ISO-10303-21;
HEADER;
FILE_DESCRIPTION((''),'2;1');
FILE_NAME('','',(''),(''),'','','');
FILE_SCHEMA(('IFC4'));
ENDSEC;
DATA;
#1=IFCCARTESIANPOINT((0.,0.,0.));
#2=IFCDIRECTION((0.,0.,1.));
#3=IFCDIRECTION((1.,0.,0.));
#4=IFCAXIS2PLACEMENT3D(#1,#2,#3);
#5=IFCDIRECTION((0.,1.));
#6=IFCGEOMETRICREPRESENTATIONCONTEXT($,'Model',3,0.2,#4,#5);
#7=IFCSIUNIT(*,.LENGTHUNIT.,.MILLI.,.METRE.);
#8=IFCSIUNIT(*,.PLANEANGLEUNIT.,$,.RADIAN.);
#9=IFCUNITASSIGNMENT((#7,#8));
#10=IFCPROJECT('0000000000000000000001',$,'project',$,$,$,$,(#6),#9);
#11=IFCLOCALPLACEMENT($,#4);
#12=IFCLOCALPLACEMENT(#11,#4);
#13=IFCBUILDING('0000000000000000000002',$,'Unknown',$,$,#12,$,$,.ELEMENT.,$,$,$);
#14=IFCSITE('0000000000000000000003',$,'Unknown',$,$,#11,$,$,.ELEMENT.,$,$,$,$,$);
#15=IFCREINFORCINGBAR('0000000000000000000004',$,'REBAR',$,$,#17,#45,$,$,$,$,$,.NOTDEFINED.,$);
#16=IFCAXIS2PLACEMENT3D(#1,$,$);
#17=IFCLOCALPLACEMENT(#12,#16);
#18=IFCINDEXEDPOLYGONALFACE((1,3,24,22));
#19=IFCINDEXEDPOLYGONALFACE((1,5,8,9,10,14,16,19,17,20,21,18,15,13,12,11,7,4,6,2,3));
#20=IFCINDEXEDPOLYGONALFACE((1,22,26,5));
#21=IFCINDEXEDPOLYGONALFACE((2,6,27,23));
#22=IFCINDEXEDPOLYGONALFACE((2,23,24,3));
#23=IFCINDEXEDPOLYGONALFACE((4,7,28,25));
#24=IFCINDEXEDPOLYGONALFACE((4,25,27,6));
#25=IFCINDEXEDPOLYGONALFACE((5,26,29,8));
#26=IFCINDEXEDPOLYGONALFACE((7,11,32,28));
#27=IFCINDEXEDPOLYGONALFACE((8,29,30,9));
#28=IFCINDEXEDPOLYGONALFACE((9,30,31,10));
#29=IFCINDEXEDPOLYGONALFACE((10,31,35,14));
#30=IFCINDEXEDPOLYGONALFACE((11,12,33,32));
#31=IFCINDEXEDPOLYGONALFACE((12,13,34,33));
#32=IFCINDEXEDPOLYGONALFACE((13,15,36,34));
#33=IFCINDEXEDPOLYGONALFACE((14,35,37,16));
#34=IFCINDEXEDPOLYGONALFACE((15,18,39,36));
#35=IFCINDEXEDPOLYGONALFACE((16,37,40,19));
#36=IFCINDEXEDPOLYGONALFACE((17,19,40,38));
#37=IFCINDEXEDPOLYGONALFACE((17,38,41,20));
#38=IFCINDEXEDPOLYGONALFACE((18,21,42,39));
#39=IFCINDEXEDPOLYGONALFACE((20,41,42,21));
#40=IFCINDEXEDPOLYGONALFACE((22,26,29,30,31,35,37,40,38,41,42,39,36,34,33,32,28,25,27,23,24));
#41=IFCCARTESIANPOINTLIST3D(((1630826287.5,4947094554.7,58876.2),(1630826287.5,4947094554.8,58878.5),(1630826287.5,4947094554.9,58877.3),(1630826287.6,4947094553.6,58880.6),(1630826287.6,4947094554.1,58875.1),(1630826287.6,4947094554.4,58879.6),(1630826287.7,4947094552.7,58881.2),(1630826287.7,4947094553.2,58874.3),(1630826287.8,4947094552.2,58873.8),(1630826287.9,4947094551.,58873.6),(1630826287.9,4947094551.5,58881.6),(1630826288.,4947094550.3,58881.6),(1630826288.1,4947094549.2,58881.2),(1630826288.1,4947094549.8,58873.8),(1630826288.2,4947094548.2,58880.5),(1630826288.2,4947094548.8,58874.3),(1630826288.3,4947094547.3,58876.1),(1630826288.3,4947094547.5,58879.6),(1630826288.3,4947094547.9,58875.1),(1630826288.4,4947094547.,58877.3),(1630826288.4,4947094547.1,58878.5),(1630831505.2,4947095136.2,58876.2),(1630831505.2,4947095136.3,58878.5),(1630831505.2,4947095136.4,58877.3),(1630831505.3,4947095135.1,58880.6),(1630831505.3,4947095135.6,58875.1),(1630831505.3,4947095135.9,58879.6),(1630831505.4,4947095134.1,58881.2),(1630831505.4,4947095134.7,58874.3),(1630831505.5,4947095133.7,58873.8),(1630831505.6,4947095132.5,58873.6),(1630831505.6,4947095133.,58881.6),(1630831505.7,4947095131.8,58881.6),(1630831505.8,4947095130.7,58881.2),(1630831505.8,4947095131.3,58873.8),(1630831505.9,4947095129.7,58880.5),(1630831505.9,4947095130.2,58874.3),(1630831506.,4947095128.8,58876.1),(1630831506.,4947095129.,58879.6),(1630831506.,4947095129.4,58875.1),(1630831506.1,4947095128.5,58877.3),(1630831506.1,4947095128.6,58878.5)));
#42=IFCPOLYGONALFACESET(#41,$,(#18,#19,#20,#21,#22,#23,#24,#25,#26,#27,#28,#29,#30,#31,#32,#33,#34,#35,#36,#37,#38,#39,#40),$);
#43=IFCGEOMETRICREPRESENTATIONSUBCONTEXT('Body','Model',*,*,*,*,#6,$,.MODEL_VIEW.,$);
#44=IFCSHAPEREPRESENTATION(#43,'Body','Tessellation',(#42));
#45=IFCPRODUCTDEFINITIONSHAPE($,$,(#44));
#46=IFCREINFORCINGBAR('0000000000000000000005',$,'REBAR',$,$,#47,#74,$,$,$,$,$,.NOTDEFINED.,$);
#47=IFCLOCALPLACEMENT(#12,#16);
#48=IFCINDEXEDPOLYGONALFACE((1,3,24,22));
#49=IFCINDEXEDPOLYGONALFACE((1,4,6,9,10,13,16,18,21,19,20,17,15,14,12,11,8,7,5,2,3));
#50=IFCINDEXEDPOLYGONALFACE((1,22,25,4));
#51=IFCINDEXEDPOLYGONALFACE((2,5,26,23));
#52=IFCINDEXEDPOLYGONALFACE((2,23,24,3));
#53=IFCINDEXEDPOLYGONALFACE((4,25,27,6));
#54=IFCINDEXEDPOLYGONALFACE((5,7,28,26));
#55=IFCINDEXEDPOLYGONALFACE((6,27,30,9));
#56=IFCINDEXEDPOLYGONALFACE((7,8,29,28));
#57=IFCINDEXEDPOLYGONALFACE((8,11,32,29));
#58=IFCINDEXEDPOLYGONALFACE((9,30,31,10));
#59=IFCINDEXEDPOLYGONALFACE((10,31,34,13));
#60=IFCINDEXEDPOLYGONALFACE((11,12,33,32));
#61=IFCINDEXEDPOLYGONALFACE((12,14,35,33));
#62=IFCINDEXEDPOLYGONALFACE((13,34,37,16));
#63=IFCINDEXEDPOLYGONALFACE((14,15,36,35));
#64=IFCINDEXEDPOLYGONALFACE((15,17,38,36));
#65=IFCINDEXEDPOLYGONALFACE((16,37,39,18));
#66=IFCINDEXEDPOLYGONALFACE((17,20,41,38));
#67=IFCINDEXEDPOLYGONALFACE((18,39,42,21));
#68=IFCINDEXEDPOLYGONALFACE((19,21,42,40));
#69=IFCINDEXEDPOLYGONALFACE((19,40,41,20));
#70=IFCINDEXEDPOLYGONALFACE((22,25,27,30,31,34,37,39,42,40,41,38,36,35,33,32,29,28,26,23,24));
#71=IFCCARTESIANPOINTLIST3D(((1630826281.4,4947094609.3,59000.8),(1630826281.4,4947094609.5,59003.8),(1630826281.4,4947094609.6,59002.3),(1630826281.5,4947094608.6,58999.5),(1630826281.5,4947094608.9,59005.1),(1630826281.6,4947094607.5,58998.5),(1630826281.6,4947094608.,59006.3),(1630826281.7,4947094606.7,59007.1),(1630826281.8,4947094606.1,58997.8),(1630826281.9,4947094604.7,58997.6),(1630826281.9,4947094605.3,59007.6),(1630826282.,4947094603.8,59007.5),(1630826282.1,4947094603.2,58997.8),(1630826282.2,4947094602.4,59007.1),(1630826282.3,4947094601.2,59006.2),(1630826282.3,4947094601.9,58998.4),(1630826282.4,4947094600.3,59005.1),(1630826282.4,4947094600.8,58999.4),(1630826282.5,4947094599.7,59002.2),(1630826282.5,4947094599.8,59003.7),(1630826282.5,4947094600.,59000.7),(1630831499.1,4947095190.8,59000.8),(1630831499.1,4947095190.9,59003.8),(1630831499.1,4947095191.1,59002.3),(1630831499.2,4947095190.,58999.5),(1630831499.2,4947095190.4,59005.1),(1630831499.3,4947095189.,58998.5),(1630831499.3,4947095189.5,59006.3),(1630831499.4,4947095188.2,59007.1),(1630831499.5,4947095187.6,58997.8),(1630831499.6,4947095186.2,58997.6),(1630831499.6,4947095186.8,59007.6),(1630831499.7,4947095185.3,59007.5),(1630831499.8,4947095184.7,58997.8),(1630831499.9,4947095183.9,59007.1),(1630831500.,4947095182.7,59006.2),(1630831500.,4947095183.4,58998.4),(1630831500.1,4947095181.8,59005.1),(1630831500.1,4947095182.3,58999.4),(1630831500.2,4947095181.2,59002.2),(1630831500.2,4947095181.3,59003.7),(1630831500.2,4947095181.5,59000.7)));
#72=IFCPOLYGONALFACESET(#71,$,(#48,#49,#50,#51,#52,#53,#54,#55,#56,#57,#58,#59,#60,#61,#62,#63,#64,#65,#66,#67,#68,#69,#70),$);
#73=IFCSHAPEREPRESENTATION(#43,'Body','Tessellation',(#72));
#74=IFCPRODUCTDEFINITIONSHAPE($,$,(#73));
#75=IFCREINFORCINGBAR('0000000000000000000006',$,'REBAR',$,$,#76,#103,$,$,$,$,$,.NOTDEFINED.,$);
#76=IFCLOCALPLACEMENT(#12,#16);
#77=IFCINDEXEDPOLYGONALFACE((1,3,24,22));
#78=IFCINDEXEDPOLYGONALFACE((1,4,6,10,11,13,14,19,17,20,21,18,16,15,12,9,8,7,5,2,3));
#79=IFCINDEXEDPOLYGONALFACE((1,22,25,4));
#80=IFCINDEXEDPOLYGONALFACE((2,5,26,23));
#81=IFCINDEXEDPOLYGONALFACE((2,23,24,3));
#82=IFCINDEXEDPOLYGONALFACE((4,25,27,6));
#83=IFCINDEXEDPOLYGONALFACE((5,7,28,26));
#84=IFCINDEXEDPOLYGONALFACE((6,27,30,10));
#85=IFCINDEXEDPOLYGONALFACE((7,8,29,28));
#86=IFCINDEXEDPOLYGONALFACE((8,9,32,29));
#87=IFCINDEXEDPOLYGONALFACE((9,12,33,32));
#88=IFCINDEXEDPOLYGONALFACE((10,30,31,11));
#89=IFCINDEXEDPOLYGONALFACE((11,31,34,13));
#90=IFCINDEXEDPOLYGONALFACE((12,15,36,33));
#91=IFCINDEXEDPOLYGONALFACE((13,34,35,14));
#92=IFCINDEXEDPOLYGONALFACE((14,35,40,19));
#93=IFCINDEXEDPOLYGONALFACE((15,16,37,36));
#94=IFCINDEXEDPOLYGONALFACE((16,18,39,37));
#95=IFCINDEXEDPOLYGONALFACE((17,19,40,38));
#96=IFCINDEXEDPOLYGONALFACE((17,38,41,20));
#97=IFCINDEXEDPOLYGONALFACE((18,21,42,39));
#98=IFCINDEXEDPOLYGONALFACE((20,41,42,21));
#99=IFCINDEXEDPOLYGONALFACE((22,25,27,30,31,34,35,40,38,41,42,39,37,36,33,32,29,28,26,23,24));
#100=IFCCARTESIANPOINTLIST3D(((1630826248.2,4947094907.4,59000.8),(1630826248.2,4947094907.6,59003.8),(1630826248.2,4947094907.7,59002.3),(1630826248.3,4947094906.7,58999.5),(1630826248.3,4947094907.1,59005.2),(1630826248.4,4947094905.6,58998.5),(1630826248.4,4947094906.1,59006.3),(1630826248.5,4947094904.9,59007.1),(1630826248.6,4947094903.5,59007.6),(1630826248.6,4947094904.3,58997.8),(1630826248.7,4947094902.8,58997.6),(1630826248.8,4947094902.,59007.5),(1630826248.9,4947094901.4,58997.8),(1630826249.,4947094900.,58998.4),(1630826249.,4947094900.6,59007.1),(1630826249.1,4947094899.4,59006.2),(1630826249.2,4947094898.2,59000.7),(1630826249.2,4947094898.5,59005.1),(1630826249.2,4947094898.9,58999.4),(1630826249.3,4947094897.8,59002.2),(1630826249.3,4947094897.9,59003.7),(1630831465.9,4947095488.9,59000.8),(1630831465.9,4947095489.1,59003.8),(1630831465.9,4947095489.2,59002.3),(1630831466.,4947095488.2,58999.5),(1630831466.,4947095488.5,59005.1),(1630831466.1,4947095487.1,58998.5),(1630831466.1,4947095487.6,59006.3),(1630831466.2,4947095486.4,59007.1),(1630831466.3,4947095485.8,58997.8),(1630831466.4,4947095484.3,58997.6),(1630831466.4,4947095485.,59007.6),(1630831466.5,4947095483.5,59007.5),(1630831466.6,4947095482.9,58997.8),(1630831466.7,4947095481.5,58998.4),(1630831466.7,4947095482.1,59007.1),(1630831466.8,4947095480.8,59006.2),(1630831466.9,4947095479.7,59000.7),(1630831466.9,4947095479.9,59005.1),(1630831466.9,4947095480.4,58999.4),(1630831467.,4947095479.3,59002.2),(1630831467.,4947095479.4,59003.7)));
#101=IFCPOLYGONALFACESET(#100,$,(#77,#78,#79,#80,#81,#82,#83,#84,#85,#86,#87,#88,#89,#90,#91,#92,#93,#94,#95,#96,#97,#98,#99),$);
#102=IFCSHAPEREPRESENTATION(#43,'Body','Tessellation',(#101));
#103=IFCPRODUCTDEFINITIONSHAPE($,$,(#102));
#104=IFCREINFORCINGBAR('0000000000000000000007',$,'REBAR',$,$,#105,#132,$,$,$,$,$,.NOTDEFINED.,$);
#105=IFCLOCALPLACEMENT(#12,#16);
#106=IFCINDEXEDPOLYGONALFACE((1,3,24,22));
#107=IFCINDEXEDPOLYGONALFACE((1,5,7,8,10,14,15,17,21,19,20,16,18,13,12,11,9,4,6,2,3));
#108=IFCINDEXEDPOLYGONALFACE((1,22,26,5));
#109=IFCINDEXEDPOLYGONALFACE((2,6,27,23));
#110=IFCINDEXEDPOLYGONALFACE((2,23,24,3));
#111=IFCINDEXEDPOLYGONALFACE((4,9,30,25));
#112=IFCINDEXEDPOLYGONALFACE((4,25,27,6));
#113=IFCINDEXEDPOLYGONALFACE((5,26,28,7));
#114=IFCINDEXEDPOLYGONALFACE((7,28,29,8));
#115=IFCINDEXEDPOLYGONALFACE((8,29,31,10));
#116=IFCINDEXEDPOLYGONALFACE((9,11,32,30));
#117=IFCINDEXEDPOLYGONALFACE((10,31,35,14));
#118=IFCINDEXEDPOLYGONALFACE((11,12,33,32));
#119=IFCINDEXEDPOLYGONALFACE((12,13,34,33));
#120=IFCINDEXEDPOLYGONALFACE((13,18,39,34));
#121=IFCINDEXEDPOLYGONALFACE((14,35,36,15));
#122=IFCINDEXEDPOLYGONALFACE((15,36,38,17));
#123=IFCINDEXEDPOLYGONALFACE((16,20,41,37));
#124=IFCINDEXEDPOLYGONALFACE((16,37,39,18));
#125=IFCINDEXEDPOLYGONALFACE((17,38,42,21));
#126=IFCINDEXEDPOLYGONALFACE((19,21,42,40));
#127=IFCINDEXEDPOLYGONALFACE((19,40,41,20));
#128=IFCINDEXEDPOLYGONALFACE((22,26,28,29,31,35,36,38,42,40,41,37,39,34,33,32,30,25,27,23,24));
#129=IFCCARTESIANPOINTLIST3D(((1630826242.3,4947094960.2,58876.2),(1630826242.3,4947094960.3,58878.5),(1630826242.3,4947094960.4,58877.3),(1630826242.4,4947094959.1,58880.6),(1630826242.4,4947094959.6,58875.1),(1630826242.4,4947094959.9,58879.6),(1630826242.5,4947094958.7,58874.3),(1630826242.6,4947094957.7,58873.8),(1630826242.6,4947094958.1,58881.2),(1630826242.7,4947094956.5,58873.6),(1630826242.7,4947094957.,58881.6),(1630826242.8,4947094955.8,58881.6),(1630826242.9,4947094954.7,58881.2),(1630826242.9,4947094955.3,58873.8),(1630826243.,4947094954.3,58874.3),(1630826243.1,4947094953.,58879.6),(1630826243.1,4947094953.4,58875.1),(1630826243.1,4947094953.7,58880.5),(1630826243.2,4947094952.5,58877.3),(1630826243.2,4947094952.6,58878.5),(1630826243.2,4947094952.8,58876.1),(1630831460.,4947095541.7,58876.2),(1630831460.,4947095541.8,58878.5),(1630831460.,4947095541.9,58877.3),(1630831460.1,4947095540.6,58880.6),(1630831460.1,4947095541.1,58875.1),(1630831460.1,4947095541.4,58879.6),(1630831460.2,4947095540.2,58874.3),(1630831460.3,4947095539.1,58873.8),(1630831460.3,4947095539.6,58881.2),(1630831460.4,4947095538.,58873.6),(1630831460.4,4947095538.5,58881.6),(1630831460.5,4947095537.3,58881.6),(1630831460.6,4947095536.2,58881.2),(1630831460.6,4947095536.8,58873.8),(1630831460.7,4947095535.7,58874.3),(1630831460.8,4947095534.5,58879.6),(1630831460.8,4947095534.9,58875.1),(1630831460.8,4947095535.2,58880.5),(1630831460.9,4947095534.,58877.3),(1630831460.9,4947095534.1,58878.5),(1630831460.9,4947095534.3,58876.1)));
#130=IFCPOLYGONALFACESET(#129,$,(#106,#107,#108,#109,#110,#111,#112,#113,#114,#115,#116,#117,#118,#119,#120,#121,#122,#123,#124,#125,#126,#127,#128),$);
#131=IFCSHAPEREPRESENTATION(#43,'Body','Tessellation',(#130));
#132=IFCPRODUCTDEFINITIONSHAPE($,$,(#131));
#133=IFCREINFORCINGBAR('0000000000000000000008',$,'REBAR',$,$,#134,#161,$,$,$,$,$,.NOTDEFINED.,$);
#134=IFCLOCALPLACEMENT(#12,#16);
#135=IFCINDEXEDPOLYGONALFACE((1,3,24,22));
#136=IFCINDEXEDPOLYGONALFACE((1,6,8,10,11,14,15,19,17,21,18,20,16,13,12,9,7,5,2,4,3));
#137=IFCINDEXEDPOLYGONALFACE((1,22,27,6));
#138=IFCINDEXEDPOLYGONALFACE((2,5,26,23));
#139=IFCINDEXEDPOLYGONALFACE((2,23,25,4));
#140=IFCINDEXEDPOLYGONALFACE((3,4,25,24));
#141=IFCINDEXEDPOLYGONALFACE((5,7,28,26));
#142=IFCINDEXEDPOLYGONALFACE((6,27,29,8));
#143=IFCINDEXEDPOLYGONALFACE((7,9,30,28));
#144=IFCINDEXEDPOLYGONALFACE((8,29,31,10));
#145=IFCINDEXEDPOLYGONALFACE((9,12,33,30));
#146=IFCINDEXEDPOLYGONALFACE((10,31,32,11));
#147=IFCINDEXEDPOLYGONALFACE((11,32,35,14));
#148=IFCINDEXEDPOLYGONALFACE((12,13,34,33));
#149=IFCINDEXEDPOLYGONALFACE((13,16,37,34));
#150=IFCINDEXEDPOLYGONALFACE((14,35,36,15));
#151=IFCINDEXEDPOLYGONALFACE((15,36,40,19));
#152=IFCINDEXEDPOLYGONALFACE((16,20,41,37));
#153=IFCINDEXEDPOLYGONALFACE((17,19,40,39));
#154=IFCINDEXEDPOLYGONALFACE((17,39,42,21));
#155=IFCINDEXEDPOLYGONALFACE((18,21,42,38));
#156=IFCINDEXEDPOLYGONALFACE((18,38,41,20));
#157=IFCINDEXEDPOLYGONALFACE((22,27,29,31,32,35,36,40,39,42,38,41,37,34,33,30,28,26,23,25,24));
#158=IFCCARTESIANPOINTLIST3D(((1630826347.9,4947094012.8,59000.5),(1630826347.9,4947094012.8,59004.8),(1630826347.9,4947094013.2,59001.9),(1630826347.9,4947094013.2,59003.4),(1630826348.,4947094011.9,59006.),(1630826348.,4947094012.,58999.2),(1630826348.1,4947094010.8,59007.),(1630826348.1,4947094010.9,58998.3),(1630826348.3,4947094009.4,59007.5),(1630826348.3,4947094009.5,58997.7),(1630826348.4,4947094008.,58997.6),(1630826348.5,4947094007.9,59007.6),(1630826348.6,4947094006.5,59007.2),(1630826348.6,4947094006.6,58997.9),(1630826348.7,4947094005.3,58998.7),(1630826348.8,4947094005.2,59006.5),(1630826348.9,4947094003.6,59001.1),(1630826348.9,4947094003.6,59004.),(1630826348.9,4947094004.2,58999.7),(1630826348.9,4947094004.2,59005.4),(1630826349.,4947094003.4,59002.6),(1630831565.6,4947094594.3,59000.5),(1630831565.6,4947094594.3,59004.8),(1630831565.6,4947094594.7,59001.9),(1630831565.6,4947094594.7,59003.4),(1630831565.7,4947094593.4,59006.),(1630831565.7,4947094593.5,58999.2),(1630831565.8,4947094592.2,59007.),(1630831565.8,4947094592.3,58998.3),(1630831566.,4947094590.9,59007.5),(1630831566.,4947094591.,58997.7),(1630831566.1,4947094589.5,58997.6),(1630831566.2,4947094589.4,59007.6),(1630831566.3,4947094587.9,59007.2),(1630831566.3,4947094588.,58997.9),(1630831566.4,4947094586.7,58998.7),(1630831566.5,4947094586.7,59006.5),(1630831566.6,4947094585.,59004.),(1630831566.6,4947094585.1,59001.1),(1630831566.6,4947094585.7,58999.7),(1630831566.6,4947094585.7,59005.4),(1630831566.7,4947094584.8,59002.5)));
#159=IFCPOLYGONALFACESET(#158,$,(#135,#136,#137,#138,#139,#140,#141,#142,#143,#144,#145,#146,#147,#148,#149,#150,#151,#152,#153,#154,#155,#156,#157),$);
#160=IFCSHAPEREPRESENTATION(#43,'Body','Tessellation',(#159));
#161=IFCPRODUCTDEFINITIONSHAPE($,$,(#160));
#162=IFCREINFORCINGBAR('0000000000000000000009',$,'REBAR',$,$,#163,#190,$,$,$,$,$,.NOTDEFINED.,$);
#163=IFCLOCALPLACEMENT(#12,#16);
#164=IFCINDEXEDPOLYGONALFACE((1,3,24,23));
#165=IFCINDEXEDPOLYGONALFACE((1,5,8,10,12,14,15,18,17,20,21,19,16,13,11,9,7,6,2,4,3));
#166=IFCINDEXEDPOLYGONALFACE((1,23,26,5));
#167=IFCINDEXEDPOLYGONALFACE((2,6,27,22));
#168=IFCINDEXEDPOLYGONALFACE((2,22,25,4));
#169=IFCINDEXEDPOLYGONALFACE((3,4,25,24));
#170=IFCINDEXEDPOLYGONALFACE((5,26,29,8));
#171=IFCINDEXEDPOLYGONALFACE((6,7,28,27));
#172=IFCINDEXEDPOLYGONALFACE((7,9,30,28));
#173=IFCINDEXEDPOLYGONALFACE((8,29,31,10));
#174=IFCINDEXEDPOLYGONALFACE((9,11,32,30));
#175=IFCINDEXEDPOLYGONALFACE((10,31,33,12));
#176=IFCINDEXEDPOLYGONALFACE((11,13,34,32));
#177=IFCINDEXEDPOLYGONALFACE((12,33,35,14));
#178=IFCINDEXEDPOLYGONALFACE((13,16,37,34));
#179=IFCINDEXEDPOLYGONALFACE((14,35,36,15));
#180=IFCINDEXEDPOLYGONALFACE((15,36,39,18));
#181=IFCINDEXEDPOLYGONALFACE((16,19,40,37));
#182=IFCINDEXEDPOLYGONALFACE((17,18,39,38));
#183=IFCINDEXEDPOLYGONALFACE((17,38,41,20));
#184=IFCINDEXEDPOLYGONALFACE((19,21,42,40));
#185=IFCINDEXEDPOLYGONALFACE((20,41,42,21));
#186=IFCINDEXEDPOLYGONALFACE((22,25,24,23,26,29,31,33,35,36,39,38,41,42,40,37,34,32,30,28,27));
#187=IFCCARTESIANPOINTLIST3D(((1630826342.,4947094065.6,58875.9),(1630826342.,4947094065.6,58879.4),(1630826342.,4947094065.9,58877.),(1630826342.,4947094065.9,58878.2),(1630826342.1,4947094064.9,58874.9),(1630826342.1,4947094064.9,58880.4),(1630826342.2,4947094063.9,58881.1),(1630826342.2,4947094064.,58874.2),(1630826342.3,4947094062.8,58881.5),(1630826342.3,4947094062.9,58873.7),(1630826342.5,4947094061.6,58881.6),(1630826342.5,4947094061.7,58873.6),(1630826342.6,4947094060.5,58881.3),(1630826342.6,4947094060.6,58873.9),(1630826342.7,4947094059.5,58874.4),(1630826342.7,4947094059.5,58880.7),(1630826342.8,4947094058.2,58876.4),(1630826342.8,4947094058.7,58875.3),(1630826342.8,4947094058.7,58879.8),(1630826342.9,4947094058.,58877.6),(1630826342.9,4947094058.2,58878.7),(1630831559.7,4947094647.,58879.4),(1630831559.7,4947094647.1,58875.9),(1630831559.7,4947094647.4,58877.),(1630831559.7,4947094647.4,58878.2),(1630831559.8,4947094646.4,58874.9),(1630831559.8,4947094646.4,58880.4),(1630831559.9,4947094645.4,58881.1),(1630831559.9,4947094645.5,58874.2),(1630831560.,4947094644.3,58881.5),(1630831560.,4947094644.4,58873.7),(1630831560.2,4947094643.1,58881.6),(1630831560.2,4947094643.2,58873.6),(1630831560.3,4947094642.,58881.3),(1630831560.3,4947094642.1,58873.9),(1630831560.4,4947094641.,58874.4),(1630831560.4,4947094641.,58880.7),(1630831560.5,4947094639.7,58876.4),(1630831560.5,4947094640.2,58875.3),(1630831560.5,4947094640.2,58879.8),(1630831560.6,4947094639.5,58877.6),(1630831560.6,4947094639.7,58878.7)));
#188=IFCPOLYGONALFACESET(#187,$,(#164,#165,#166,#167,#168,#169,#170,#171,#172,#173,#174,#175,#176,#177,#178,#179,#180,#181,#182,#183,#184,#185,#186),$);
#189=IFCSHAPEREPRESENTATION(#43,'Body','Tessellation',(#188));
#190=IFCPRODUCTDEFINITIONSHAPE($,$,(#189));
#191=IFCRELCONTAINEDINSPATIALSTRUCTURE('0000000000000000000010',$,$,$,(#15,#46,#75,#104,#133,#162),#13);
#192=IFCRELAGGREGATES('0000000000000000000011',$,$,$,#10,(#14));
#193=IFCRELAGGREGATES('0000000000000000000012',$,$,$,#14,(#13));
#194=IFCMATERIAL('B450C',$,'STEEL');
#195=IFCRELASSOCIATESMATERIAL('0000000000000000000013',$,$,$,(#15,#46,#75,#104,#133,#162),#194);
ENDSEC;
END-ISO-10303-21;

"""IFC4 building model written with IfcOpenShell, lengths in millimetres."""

from ifc_helpers import new_model, entity, si_unit, direction, frame, origin_with_axes, place, context, subcontext, project, spatial, material, element, save


model = new_model("IFC4")

# Units and contexts
model_context = context("Model", 3, precision=0.2, world=origin_with_axes(), true_north=direction((0.0, 1.0)))
body_context = subcontext(model_context, "Body", "Model", "MODEL_VIEW")
ifc_project = project(units=[si_unit("LENGTHUNIT", "METRE", prefix="MILLI"), si_unit("PLANEANGLEUNIT", "RADIAN")], contexts=[model_context])

# Site, building
site_placement = place(None, origin_with_axes())
site = spatial("IfcSite", under=ifc_project, at=site_placement, Name="Unknown", CompositionType="ELEMENT")
building_placement = place(site_placement, origin_with_axes())
building = spatial("IfcBuilding", under=site, at=building_placement, Name="Unknown", CompositionType="ELEMENT")

# Reinforcing bars
ifc_material = material(Name="B450C", Category="STEEL")
reinforcing_bar_1_placement = place(building_placement, frame((1630831505.6, 4947095132.4, 58877.6), z_axis=(0.007106, -0.063762, -0.99794), x_axis=(-0.993847, -0.110757, 0.0)))
element("IfcReinforcingBar", 1, at=reinforcing_bar_1_placement, inside=building, material=ifc_material, Name="REBAR", PredefinedType="NOTDEFINED", context=body_context, shape_type="AdvancedSweptSolid", body=[
    entity("IfcSweptDiskSolid", entity("IfcIndexedPolyCurve", entity("IfcCartesianPointList3D", [[0.0, 0.0, 0.0], [5250.0, 0.0, 0.0]]), [entity("IfcLineIndex", [1, 2])]), 4.0),
])
reinforcing_bar_2_placement = place(building_placement, frame((1630831499.7, 4947095186.1, 59002.6), z_axis=(0.007106, -0.063762, -0.99794), x_axis=(-0.993847, -0.110757, 0.0)))
element("IfcReinforcingBar", 2, at=reinforcing_bar_2_placement, inside=building, material=ifc_material, Name="REBAR", PredefinedType="NOTDEFINED", context=body_context, shape_type="AdvancedSweptSolid", body=[
    entity("IfcSweptDiskSolid", entity("IfcIndexedPolyCurve", entity("IfcCartesianPointList3D", [[0.0, 0.0, 0.0], [5250.0, 0.0, 0.0]]), [entity("IfcLineIndex", [1, 2])]), 5.0),
])
reinforcing_bar_3_placement = place(building_placement, frame((1630831466.4, 4947095484.3, 59002.6), z_axis=(0.007106, -0.063762, -0.99794), x_axis=(-0.993847, -0.110757, 0.0)))
element("IfcReinforcingBar", 3, at=reinforcing_bar_3_placement, inside=building, material=ifc_material, Name="REBAR", PredefinedType="NOTDEFINED", context=body_context, shape_type="AdvancedSweptSolid", body=[
    entity("IfcSweptDiskSolid", entity("IfcIndexedPolyCurve", entity("IfcCartesianPointList3D", [[0.0, 0.0, 0.0], [5250.0, 0.0, 0.0]]), [entity("IfcLineIndex", [1, 2])]), 5.0),
])
reinforcing_bar_4_placement = place(building_placement, frame((1630831460.4, 4947095537.9, 58877.6), z_axis=(0.007106, -0.063762, -0.99794), x_axis=(-0.993847, -0.110757, 0.0)))
element("IfcReinforcingBar", 4, at=reinforcing_bar_4_placement, inside=building, material=ifc_material, Name="REBAR", PredefinedType="NOTDEFINED", context=body_context, shape_type="AdvancedSweptSolid", body=[
    entity("IfcSweptDiskSolid", entity("IfcIndexedPolyCurve", entity("IfcCartesianPointList3D", [[0.0, 0.0, 0.0], [5250.0, 0.0, 0.0]]), [entity("IfcLineIndex", [1, 2])]), 4.0),
])
reinforcing_bar_5_placement = place(building_placement, frame((1630831566.1, 4947094589.8, 59002.6), z_axis=(0.007106, -0.063762, -0.99794), x_axis=(-0.993847, -0.110757, 0.0)))
element("IfcReinforcingBar", 5, at=reinforcing_bar_5_placement, inside=building, material=ifc_material, Name="REBAR", PredefinedType="NOTDEFINED", context=body_context, shape_type="AdvancedSweptSolid", body=[
    entity("IfcSweptDiskSolid", entity("IfcIndexedPolyCurve", entity("IfcCartesianPointList3D", [[0.0, 0.0, 0.0], [5250.0, 0.0, 0.0]]), [entity("IfcLineIndex", [1, 2])]), 5.0),
])
reinforcing_bar_6_placement = place(building_placement, frame((1630831560.1, 4947094643.5, 58877.6), z_axis=(0.007106, -0.063762, -0.99794), x_axis=(-0.993847, -0.110757, 0.0)))
element("IfcReinforcingBar", 6, at=reinforcing_bar_6_placement, inside=building, material=ifc_material, Name="REBAR", PredefinedType="NOTDEFINED", context=body_context, shape_type="AdvancedSweptSolid", body=[
    entity("IfcSweptDiskSolid", entity("IfcIndexedPolyCurve", entity("IfcCartesianPointList3D", [[0.0, 0.0, 0.0], [5250.0, 0.0, 0.0]]), [entity("IfcLineIndex", [1, 2])]), 4.0),
])

save(model, "model.ifc")
